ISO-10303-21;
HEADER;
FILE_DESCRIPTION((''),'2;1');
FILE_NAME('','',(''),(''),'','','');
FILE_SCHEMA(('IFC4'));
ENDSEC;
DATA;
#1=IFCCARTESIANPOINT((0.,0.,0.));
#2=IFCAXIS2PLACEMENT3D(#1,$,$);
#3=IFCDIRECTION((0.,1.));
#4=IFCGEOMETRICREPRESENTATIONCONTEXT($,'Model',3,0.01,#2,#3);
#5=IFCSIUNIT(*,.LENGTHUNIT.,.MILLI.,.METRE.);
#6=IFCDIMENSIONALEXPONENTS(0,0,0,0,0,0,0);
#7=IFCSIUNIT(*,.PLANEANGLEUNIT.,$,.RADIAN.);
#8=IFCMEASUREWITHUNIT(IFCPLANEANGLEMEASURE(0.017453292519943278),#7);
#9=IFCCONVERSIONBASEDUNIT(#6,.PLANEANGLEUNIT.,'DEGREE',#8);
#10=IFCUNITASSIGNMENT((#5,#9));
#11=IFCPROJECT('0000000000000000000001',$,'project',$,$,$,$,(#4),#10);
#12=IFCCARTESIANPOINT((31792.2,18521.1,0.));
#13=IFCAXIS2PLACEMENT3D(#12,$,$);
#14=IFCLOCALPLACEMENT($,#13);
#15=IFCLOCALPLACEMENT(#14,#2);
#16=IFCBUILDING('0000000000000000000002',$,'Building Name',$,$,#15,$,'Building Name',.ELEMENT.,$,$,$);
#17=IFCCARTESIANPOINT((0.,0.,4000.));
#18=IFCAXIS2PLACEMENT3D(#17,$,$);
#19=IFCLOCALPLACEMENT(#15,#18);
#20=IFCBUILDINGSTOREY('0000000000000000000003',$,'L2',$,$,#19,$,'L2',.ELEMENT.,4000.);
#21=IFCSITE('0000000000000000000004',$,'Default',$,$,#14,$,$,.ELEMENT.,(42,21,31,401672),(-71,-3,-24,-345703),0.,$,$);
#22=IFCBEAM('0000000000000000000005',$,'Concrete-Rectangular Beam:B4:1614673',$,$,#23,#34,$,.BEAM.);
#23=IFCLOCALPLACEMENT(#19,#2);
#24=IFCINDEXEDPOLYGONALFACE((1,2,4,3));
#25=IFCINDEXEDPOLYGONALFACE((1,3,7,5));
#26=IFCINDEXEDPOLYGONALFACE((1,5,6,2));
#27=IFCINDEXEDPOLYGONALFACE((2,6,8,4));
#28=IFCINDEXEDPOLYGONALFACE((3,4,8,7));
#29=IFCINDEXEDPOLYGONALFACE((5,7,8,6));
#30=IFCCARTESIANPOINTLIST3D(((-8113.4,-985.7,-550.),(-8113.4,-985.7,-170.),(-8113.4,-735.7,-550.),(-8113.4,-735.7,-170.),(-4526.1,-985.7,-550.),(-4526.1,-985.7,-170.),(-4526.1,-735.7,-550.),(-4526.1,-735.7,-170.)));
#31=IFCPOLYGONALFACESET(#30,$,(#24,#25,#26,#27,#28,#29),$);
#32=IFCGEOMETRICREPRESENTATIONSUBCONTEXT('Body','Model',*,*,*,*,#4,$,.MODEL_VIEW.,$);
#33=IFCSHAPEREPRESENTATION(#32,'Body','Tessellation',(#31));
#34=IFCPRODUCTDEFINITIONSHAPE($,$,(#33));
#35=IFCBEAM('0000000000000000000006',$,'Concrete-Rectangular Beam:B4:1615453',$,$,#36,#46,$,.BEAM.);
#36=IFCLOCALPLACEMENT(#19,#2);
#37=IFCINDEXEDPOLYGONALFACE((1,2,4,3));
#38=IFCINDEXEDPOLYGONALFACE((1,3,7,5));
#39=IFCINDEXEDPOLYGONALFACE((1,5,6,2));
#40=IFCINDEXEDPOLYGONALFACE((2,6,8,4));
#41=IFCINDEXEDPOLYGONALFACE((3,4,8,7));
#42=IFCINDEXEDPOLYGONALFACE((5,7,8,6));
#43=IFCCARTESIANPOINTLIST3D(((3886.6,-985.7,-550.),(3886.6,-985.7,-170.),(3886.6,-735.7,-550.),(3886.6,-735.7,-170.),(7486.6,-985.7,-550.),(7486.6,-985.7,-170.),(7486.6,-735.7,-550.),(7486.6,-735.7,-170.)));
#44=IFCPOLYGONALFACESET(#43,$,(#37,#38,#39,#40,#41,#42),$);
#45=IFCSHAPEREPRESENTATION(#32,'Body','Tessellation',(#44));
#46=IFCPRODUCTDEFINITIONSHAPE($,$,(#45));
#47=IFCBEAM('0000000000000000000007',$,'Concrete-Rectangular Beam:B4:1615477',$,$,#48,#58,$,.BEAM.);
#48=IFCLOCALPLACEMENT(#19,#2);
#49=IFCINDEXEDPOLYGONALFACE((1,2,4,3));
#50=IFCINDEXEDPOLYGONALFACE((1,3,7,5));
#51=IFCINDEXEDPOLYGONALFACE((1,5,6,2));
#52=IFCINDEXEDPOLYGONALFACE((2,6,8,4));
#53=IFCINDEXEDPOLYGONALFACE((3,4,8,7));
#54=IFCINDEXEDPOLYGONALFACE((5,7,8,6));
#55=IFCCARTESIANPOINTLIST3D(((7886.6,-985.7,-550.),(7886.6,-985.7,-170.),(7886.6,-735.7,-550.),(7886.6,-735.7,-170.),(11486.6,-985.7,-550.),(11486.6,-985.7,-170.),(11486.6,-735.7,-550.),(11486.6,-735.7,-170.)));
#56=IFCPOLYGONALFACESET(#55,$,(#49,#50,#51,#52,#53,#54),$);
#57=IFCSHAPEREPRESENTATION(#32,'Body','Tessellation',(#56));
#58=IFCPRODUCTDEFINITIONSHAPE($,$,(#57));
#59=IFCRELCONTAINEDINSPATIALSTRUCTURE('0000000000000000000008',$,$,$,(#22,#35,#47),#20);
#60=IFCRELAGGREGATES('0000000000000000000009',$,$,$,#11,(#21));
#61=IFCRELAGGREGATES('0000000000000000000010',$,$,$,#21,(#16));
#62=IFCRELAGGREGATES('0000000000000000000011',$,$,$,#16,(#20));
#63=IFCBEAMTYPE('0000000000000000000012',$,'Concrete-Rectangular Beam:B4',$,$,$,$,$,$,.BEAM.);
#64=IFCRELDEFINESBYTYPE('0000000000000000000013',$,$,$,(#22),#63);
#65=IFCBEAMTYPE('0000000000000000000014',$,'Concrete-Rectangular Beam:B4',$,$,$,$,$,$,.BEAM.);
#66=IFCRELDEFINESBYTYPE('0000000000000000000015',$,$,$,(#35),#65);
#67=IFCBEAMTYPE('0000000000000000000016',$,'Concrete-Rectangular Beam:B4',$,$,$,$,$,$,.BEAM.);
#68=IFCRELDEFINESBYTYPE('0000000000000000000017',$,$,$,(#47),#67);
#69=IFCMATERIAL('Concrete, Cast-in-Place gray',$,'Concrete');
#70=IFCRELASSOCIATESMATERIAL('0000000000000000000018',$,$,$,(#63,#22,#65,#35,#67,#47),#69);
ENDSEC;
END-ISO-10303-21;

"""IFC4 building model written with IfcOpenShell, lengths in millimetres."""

from ifc_helpers import new_model, entity, si_unit, converted_unit, direction, frame, origin, place, context, subcontext, project, spatial, indexed_curve, outline, extrude, source, transform, mapped, material, type_object, type_shapes, element, save


model = new_model("IFC4")

# Units and contexts
model_context = context("Model", 3, precision=0.01, world=origin(), true_north=direction((0.0, 1.0)))
body_context = subcontext(model_context, "Body", "Model", "MODEL_VIEW")
ifc_project = project(units=[si_unit("LENGTHUNIT", "METRE", prefix="MILLI"), converted_unit("PLANEANGLEUNIT", "DEGREE", entity("IfcPlaneAngleMeasure", 0.017453292519943278), si_unit("PLANEANGLEUNIT", "RADIAN"), dimensions=[0, 0, 0, 0, 0, 0, 0])], contexts=[model_context])

# Site, building, storey
site_placement = place(None, frame((31792.2, 18521.1, 0.0)))
site = spatial("IfcSite", under=ifc_project, at=site_placement, Name="Default", CompositionType="ELEMENT", RefLatitude=(42, 21, 31, 401672), RefLongitude=(-71, -3, -24, -345703), RefElevation=0.0)
building_placement = place(site_placement, origin())
building = spatial("IfcBuilding", under=site, at=building_placement, Name="Building Name", LongName="Building Name", CompositionType="ELEMENT")
storey_placement = place(building_placement, frame((0.0, 0.0, 4000.0)))
storey = spatial("IfcBuildingStorey", under=building, at=storey_placement, Name="L2", LongName="L2", CompositionType="ELEMENT", Elevation=4000.0)

# Beams
ifc_material = material(Name="Concrete, Cast-in-Place gray", Category="Concrete")
beam_type_1 = type_object("IfcBeamType", Name="Concrete-Rectangular Beam:B4", PredefinedType="BEAM", material=ifc_material)
shared_shape_1 = source(origin(), body_context, "Body", "SweptSolid", [
    extrude(outline(indexed_curve([(-190.0, -125.0), (190.0, -125.0), (190.0, 125.0), (-190.0, 125.0), (-190.0, -125.0)], self_intersect=False)), frame((-8113.4, -860.7, 3640.0), z_axis=(1.0, 0.0, 0.0), x_axis=(0.0, 0.0, -1.0)), (0.0, 0.0, 1.0), 3587.3),
])
type_shapes(beam_type_1, [shared_shape_1])
beam_1_placement = place(storey_placement, frame((0.0, 0.0, -4000.0)))
element("IfcBeam", 1, at=beam_1_placement, inside=storey, type_object=beam_type_1, material=ifc_material, Name="Concrete-Rectangular Beam:B4:1614673", PredefinedType="BEAM", context=body_context, shape_type="MappedRepresentation", body=[
    mapped(shared_shape_1, transform((0.0, 0.0, 0.0), scale=1.0)),
])
beam_type_2 = type_object("IfcBeamType", Name="Concrete-Rectangular Beam:B4", PredefinedType="BEAM", material=ifc_material)
shared_shape_2 = source(origin(), body_context, "Body", "SweptSolid", [
    extrude(outline(indexed_curve([(-190.0, -125.0), (190.0, -125.0), (190.0, 125.0), (-190.0, 125.0), (-190.0, -125.0)], self_intersect=False)), frame((3886.6, -860.7, 3640.0), z_axis=(1.0, 0.0, 0.0), x_axis=(0.0, 0.0, -1.0)), (0.0, 0.0, 1.0), 3600.0),
])
type_shapes(beam_type_2, [shared_shape_2])
beam_2_placement = place(storey_placement, frame((0.0, 0.0, -4000.0)))
element("IfcBeam", 2, at=beam_2_placement, inside=storey, type_object=beam_type_2, material=ifc_material, Name="Concrete-Rectangular Beam:B4:1615453", PredefinedType="BEAM", context=body_context, shape_type="MappedRepresentation", body=[
    mapped(shared_shape_2, transform((0.0, 0.0, 0.0), scale=1.0)),
])
beam_type_3 = type_object("IfcBeamType", Name="Concrete-Rectangular Beam:B4", PredefinedType="BEAM", material=ifc_material)
shared_shape_3 = source(origin(), body_context, "Body", "SweptSolid", [
    extrude(outline(indexed_curve([(-190.0, -125.0), (190.0, -125.0), (190.0, 125.0), (-190.0, 125.0), (-190.0, -125.0)], self_intersect=False)), frame((7886.6, -860.7, 3640.0), z_axis=(1.0, 0.0, 0.0), x_axis=(0.0, 0.0, -1.0)), (0.0, 0.0, 1.0), 3600.0),
])
type_shapes(beam_type_3, [shared_shape_3])
beam_3_placement = place(storey_placement, frame((0.0, 0.0, -4000.0)))
element("IfcBeam", 3, at=beam_3_placement, inside=storey, type_object=beam_type_3, material=ifc_material, Name="Concrete-Rectangular Beam:B4:1615477", PredefinedType="BEAM", context=body_context, shape_type="MappedRepresentation", body=[
    mapped(shared_shape_3, transform((0.0, 0.0, 0.0), scale=1.0)),
])

save(model, "model.ifc")
